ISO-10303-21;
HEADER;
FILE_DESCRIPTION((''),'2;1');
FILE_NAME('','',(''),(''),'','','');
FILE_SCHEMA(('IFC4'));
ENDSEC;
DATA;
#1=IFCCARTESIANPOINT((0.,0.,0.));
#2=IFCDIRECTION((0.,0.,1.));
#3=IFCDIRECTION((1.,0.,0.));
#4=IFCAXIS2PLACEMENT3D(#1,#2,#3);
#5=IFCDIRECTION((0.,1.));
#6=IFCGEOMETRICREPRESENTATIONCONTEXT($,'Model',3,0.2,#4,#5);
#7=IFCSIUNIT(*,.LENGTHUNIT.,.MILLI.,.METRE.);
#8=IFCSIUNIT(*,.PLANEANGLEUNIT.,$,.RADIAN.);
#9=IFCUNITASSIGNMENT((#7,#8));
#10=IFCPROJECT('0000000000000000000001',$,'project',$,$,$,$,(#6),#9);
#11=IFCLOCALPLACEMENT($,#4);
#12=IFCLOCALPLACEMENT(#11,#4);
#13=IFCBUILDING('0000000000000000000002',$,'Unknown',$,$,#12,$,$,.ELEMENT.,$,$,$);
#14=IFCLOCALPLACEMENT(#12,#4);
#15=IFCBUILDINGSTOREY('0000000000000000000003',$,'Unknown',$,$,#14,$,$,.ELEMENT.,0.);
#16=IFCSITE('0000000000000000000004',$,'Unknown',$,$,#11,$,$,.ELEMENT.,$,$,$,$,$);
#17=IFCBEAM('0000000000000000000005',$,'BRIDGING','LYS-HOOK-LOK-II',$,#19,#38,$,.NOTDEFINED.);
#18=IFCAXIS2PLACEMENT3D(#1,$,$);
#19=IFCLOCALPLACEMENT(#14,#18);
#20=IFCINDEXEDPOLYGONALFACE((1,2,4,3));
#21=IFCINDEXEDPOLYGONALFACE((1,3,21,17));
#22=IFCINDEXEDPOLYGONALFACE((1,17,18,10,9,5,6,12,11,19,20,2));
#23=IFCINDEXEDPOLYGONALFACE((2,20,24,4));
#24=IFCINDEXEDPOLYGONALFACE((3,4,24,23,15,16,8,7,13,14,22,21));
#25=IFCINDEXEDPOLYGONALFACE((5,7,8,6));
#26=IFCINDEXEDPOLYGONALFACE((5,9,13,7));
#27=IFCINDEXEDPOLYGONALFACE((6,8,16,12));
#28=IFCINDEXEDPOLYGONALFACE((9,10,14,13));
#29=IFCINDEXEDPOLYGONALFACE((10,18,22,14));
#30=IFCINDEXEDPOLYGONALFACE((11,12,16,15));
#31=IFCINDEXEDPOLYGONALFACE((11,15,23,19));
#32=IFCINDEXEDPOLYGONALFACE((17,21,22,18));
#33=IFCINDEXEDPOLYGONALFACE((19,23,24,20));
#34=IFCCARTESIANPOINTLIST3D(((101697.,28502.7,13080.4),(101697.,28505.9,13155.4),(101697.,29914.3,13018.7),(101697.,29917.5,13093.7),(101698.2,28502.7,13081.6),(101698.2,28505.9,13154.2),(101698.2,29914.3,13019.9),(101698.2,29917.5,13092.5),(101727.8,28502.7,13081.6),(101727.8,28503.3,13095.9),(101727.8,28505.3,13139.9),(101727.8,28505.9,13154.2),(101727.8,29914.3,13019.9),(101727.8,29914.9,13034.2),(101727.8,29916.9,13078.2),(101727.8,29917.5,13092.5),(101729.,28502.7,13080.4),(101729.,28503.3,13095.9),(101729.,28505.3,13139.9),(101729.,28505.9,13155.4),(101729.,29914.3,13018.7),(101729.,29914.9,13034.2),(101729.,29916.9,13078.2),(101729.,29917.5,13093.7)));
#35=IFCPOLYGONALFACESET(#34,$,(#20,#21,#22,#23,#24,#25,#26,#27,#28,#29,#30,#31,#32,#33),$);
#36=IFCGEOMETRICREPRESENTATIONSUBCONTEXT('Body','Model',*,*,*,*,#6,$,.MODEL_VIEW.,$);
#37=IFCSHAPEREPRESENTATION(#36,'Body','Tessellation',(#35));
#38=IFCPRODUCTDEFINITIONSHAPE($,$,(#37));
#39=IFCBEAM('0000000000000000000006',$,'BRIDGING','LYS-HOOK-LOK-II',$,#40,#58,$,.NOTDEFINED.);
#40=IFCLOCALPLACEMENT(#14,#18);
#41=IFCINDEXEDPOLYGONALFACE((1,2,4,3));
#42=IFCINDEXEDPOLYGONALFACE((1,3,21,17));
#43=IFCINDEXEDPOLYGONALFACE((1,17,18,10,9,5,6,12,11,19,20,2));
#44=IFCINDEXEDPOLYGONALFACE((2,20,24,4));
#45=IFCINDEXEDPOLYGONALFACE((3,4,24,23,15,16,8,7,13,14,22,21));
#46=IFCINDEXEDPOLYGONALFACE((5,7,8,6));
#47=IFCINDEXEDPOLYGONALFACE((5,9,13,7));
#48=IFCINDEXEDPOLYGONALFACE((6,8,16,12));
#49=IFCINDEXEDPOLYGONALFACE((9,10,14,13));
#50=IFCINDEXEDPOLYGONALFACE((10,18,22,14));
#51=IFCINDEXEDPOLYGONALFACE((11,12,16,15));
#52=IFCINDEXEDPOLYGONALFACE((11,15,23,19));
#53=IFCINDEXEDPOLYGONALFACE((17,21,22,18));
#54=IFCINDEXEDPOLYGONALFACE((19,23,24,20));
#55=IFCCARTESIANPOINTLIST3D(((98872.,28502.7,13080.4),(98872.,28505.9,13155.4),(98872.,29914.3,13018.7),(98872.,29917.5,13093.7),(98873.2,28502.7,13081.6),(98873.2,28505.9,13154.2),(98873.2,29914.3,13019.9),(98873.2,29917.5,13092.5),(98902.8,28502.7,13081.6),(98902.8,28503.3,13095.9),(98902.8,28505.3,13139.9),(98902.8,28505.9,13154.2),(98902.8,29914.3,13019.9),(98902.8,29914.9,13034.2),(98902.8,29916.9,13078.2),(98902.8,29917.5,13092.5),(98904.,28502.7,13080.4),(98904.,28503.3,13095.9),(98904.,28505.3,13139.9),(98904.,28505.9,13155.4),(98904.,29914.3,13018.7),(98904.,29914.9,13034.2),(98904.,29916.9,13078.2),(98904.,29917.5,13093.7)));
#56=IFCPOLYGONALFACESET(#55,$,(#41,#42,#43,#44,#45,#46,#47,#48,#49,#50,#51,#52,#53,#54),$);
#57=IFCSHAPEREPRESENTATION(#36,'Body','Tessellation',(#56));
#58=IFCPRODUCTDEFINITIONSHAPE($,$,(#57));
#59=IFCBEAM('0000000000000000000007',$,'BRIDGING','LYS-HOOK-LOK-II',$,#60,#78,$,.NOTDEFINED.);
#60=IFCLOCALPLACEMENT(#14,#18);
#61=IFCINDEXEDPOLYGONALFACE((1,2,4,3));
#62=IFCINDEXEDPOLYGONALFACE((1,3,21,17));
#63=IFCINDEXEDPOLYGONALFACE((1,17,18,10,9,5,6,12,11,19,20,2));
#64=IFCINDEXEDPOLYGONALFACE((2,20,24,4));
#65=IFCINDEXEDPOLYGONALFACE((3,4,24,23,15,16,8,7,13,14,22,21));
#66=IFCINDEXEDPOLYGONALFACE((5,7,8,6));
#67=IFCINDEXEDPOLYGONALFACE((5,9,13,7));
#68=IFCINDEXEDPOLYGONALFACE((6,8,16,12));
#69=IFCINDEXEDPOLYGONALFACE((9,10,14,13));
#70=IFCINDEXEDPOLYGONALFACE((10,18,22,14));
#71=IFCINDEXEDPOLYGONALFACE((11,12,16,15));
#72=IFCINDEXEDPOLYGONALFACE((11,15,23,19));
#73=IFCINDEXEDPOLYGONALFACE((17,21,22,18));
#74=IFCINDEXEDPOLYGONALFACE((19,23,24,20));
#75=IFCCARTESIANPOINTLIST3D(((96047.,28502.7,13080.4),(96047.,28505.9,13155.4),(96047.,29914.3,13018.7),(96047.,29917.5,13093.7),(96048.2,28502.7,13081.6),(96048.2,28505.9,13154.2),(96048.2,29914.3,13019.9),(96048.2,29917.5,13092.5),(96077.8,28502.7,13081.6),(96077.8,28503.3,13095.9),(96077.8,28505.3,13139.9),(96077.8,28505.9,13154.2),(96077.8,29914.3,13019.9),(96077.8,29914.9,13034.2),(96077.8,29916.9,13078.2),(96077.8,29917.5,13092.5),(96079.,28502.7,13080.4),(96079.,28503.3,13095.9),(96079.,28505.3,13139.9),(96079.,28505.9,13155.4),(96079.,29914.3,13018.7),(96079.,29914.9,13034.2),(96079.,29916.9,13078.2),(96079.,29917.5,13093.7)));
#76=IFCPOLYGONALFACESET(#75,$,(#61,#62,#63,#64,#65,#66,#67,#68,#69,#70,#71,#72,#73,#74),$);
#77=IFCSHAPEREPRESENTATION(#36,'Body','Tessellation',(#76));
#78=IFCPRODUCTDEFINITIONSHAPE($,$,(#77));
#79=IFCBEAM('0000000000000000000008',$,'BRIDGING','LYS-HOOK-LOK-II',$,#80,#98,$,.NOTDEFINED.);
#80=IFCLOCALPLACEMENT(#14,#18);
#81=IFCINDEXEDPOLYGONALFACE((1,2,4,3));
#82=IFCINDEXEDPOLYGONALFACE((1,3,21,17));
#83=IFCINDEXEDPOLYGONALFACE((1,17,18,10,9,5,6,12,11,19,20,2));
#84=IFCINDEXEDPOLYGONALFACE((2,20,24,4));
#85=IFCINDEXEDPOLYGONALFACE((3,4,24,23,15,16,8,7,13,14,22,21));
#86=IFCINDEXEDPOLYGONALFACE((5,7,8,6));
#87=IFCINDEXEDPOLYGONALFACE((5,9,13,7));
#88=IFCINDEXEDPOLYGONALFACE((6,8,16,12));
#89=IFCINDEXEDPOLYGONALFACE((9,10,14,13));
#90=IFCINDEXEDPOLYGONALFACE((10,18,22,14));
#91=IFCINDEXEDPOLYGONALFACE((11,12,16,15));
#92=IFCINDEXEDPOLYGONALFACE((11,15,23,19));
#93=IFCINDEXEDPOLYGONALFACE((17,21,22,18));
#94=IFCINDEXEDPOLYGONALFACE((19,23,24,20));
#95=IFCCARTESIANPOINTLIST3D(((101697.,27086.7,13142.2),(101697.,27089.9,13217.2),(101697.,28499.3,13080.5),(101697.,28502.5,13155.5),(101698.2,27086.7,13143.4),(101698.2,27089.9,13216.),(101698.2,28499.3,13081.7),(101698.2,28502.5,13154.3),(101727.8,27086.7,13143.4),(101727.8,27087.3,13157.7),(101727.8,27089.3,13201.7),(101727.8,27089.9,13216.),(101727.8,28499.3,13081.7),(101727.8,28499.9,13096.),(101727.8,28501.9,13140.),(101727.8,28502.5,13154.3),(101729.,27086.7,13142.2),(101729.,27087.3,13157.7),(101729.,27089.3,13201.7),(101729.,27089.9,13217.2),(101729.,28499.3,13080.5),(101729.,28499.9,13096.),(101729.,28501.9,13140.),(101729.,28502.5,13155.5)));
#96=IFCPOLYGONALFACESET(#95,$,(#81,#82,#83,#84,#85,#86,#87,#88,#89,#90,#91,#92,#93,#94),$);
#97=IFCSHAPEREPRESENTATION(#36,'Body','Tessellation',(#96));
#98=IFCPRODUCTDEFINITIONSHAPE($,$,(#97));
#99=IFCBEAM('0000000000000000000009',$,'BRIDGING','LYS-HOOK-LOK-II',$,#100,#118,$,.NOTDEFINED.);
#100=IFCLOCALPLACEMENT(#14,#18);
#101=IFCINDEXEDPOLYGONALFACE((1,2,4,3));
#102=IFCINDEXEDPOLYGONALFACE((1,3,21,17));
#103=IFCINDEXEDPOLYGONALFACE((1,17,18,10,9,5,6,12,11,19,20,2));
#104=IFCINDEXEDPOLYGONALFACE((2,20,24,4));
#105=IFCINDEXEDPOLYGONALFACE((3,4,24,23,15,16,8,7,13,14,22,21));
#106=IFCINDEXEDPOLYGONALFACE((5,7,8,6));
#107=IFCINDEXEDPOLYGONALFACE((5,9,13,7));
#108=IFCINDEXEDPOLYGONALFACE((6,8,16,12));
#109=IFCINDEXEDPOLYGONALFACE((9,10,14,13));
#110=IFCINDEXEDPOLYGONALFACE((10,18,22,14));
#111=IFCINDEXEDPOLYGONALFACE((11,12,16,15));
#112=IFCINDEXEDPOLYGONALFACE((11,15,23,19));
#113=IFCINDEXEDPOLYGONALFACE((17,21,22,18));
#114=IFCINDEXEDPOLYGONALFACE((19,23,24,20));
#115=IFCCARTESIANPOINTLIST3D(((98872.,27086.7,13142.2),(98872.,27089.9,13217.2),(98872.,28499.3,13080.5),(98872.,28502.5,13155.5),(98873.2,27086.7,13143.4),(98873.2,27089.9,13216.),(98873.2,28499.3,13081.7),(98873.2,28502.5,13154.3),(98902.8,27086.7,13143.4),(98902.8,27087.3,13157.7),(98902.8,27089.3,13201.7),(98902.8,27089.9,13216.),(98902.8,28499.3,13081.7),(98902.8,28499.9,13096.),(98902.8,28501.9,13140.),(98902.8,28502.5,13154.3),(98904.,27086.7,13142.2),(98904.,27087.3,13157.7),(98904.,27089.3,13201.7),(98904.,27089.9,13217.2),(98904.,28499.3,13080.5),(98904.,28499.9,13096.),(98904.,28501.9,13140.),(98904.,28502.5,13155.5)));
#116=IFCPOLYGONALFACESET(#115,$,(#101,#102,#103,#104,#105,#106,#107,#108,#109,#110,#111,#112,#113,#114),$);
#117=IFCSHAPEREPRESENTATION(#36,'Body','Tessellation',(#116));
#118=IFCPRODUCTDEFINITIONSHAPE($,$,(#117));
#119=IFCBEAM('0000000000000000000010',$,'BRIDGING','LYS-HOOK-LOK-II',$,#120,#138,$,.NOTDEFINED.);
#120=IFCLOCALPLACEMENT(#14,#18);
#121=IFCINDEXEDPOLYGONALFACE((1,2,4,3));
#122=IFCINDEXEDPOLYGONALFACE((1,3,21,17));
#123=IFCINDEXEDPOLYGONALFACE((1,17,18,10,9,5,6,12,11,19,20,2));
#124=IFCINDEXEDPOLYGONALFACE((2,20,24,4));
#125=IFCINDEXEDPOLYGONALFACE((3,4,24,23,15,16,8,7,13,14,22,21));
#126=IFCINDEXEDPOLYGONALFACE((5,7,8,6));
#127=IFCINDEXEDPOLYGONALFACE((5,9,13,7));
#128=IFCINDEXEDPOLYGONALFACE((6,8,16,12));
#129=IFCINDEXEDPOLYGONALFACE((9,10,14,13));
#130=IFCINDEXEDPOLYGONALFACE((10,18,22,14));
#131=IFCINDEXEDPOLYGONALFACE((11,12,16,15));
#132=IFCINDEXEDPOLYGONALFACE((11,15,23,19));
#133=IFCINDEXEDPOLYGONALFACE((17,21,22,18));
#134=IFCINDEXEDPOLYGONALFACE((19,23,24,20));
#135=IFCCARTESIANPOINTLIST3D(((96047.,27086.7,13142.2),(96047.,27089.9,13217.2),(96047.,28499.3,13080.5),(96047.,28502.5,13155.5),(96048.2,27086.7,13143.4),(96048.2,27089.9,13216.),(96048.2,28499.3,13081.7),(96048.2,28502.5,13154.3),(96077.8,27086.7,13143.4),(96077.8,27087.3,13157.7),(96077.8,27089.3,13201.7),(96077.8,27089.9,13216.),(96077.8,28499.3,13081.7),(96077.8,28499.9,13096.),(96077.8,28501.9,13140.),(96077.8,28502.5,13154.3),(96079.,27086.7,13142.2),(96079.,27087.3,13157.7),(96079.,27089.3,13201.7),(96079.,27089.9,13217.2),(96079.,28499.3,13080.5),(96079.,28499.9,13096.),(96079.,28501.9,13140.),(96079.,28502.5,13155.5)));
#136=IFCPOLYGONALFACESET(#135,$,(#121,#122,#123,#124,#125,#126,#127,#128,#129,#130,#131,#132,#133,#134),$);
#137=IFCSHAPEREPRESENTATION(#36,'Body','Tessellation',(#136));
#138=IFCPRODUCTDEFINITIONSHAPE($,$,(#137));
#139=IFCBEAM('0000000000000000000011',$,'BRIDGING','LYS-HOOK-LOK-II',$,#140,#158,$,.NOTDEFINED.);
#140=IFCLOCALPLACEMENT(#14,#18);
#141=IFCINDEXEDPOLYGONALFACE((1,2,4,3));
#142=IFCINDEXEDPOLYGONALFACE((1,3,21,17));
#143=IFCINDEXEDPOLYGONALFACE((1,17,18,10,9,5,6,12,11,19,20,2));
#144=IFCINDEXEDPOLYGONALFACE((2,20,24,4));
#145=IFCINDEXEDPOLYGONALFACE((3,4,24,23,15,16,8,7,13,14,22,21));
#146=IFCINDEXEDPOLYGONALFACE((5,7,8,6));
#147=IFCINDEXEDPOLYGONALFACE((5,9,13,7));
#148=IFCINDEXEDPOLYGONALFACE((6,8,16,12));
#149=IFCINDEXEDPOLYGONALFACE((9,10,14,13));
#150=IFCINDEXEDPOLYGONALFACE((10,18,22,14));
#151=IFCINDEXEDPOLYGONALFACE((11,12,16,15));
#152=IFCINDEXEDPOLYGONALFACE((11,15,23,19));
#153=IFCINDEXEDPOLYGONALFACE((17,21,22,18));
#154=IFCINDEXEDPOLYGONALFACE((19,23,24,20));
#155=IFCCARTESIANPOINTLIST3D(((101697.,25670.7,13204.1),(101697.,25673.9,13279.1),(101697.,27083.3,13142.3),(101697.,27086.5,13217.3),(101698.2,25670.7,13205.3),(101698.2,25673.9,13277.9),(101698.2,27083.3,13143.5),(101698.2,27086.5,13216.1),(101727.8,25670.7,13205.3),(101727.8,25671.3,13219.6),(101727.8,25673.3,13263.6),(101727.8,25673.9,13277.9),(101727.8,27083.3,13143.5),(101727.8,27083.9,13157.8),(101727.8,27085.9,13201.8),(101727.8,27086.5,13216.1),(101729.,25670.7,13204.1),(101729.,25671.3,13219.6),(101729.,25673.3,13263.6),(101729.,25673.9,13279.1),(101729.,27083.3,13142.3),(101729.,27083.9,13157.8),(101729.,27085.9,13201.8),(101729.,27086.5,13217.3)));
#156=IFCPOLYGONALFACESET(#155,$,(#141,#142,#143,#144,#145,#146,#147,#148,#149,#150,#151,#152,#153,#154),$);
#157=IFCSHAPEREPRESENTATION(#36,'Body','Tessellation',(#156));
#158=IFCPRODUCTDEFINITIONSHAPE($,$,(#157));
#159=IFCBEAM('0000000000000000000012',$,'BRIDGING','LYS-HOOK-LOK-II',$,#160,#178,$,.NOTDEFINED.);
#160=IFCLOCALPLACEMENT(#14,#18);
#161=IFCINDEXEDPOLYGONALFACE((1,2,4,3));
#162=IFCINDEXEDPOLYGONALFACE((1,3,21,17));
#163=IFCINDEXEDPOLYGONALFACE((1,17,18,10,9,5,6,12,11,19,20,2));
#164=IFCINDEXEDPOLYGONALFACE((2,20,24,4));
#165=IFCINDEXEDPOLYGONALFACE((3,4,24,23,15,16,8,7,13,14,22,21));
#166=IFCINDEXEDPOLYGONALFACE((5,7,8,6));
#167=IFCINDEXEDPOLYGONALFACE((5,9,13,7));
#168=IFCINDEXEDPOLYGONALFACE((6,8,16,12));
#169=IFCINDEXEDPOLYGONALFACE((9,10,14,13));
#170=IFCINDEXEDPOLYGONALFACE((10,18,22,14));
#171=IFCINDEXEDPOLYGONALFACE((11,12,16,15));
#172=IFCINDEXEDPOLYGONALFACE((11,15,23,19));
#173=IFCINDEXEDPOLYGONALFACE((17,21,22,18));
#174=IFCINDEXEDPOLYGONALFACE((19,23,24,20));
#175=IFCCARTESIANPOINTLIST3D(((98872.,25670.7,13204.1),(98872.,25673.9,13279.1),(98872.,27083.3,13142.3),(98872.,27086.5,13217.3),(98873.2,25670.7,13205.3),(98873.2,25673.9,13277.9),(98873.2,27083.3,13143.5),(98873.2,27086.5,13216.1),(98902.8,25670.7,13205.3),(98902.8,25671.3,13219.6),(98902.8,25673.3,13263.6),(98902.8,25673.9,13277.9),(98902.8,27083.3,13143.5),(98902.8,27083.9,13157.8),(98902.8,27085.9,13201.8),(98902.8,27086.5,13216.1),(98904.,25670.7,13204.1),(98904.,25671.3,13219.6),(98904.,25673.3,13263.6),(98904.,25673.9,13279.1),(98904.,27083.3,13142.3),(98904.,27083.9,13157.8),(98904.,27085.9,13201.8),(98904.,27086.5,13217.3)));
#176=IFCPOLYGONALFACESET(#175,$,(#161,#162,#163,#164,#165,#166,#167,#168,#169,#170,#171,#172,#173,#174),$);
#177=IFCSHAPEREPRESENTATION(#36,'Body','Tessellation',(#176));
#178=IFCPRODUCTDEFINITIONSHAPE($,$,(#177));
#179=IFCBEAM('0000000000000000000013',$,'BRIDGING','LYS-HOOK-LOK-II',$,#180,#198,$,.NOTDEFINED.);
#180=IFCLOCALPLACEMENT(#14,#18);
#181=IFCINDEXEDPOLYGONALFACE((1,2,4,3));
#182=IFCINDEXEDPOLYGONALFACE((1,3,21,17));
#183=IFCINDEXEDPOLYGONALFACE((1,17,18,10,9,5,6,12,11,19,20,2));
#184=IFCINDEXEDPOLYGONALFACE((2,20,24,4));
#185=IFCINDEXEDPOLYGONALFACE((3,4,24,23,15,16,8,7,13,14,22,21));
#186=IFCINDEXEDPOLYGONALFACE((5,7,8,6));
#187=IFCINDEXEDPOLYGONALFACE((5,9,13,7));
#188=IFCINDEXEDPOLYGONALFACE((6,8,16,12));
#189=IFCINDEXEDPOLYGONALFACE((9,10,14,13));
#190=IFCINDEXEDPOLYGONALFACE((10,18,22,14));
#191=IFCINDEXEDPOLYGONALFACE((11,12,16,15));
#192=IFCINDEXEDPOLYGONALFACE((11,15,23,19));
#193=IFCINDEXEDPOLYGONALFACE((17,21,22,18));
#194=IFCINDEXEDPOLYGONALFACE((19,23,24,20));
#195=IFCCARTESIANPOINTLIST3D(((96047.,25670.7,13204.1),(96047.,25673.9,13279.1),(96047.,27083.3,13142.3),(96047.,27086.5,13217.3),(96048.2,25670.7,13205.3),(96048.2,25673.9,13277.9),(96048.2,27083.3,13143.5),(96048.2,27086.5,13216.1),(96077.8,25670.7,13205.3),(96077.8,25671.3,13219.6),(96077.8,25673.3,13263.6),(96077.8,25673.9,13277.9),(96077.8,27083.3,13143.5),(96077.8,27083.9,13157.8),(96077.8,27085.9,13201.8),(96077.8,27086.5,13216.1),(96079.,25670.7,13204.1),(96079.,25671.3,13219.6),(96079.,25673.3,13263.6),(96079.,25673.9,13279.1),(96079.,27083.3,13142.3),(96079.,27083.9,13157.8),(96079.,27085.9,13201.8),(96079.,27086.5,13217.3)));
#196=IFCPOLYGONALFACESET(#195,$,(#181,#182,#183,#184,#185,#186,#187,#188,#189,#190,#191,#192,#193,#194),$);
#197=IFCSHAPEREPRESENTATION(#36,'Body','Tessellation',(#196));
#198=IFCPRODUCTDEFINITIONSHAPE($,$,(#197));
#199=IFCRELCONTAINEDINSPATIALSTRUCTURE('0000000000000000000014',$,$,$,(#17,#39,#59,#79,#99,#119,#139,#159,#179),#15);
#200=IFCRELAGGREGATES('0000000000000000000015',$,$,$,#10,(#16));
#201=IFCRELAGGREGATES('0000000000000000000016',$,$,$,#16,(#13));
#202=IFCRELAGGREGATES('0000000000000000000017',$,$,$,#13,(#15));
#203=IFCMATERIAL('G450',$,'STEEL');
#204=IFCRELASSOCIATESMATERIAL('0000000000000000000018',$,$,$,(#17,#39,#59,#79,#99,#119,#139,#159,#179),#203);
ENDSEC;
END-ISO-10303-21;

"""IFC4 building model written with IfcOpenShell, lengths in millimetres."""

from ifc_helpers import new_model, si_unit, direction, frame, origin_with_axes, place, context, subcontext, project, spatial, line, indexed_curve, outline, extrude, material, element, save


model = new_model("IFC4")

# Units and contexts
model_context = context("Model", 3, precision=0.2, world=origin_with_axes(), true_north=direction((0.0, 1.0)))
body_context = subcontext(model_context, "Body", "Model", "MODEL_VIEW")
ifc_project = project(units=[si_unit("LENGTHUNIT", "METRE", prefix="MILLI"), si_unit("PLANEANGLEUNIT", "RADIAN")], contexts=[model_context])

# Site, building, storey
site_placement = place(None, origin_with_axes())
site = spatial("IfcSite", under=ifc_project, at=site_placement, Name="Unknown", CompositionType="ELEMENT")
building_placement = place(site_placement, origin_with_axes())
building = spatial("IfcBuilding", under=site, at=building_placement, Name="Unknown", CompositionType="ELEMENT")
storey_placement = place(building_placement, origin_with_axes())
storey = spatial("IfcBuildingStorey", under=building, at=storey_placement, Name="Unknown", CompositionType="ELEMENT", Elevation=0.0)

# Beams
ifc_material_1 = material(Name="G450", Category="STEEL")
for number, where, z_axis, x_axis, name in (
    (1, (101713.0, 28504.3, 13117.9), (1.0, 0.0, 0.0), (0.0, 0.999046, -0.043668), "BRIDGING"),
    (2, (98888.0, 28504.3, 13117.9), (1.0, 0.0, 0.0), (0.0, 0.999046, -0.043668), "BRIDGING"),
    (3, (96063.0, 28504.3, 13117.9), (1.0, 0.0, 0.0), (0.0, 0.999046, -0.043668), "BRIDGING"),
):
    element("IfcBeam", number, at=place(storey_placement, frame(where, z_axis=z_axis, x_axis=x_axis)), inside=storey, material=ifc_material_1, Name=name, Description="LYS-HOOK-LOK-II", PredefinedType="NOTDEFINED", context=body_context, shape_type="SolidModel", body=[
        extrude(outline(indexed_curve([(16.0, -37.5), (16.0, -22.0), (14.8, -22.0), (14.8, -36.3), (-14.8, -36.3), (-14.8, 36.3), (14.8, 36.3), (14.8, 22.0), (16.0, 22.0), (16.0, 37.5), (-16.0, 37.5), (-16.0, -37.5)], segments=[line(1, 2, 3, 4, 5, 6, 7, 8, 9, 10, 11, 12, 1)])), frame((0.0, 0.0, 0.0), z_axis=(-1.0, 0.0, 0.0), x_axis=(0.0, 0.0, 1.0)), (0.0, 0.0, -1.0), 1412.9),
    ])
for number, where, z_axis, x_axis, name in (
    (4, (101713.0, 27088.3, 13179.7), (1.0, 0.0, 0.0), (0.0, 0.999047, -0.043637), "BRIDGING"),
    (5, (98888.0, 27088.3, 13179.7), (1.0, 0.0, 0.0), (0.0, 0.999047, -0.043637), "BRIDGING"),
    (6, (96063.0, 27088.3, 13179.7), (1.0, 0.0, 0.0), (0.0, 0.999047, -0.043637), "BRIDGING"),
):
    element("IfcBeam", number, at=place(storey_placement, frame(where, z_axis=z_axis, x_axis=x_axis)), inside=storey, material=ifc_material_1, Name=name, Description="LYS-HOOK-LOK-II", PredefinedType="NOTDEFINED", context=body_context, shape_type="SolidModel", body=[
        extrude(outline(indexed_curve([(16.0, -37.5), (16.0, -22.0), (14.8, -22.0), (14.8, -36.3), (-14.8, -36.3), (-14.8, 36.3), (14.8, 36.3), (14.8, 22.0), (16.0, 22.0), (16.0, 37.5), (-16.0, 37.5), (-16.0, -37.5)], segments=[line(1, 2, 3, 4, 5, 6, 7, 8, 9, 10, 11, 12, 1)])), frame((0.0, 0.0, 0.0), z_axis=(-1.0, 0.0, 0.0), x_axis=(0.0, 0.0, 1.0)), (0.0, 0.0, -1.0), 1413.9),
    ])
for number, where, z_axis, x_axis, name in (
    (7, (101713.0, 25672.3, 13241.6), (1.0, 0.0, 0.0), (0.0, 0.999044, -0.043707), "BRIDGING"),
    (8, (98888.0, 25672.3, 13241.6), (1.0, 0.0, 0.0), (0.0, 0.999044, -0.043707), "BRIDGING"),
    (9, (96063.0, 25672.3, 13241.6), (1.0, 0.0, 0.0), (0.0, 0.999044, -0.043707), "BRIDGING"),
):
    element("IfcBeam", number, at=place(storey_placement, frame(where, z_axis=z_axis, x_axis=x_axis)), inside=storey, material=ifc_material_1, Name=name, Description="LYS-HOOK-LOK-II", PredefinedType="NOTDEFINED", context=body_context, shape_type="SolidModel", body=[
        extrude(outline(indexed_curve([(16.0, -37.5), (16.0, -22.0), (14.8, -22.0), (14.8, -36.3), (-14.8, -36.3), (-14.8, 36.3), (14.8, 36.3), (14.8, 22.0), (16.0, 22.0), (16.0, 37.5), (-16.0, 37.5), (-16.0, -37.5)], segments=[line(1, 2, 3, 4, 5, 6, 7, 8, 9, 10, 11, 12, 1)])), frame((0.0, 0.0, 0.0), z_axis=(-1.0, 0.0, 0.0), x_axis=(0.0, 0.0, 1.0)), (0.0, 0.0, -1.0), 1414.0),
    ])

save(model, "model.ifc")
